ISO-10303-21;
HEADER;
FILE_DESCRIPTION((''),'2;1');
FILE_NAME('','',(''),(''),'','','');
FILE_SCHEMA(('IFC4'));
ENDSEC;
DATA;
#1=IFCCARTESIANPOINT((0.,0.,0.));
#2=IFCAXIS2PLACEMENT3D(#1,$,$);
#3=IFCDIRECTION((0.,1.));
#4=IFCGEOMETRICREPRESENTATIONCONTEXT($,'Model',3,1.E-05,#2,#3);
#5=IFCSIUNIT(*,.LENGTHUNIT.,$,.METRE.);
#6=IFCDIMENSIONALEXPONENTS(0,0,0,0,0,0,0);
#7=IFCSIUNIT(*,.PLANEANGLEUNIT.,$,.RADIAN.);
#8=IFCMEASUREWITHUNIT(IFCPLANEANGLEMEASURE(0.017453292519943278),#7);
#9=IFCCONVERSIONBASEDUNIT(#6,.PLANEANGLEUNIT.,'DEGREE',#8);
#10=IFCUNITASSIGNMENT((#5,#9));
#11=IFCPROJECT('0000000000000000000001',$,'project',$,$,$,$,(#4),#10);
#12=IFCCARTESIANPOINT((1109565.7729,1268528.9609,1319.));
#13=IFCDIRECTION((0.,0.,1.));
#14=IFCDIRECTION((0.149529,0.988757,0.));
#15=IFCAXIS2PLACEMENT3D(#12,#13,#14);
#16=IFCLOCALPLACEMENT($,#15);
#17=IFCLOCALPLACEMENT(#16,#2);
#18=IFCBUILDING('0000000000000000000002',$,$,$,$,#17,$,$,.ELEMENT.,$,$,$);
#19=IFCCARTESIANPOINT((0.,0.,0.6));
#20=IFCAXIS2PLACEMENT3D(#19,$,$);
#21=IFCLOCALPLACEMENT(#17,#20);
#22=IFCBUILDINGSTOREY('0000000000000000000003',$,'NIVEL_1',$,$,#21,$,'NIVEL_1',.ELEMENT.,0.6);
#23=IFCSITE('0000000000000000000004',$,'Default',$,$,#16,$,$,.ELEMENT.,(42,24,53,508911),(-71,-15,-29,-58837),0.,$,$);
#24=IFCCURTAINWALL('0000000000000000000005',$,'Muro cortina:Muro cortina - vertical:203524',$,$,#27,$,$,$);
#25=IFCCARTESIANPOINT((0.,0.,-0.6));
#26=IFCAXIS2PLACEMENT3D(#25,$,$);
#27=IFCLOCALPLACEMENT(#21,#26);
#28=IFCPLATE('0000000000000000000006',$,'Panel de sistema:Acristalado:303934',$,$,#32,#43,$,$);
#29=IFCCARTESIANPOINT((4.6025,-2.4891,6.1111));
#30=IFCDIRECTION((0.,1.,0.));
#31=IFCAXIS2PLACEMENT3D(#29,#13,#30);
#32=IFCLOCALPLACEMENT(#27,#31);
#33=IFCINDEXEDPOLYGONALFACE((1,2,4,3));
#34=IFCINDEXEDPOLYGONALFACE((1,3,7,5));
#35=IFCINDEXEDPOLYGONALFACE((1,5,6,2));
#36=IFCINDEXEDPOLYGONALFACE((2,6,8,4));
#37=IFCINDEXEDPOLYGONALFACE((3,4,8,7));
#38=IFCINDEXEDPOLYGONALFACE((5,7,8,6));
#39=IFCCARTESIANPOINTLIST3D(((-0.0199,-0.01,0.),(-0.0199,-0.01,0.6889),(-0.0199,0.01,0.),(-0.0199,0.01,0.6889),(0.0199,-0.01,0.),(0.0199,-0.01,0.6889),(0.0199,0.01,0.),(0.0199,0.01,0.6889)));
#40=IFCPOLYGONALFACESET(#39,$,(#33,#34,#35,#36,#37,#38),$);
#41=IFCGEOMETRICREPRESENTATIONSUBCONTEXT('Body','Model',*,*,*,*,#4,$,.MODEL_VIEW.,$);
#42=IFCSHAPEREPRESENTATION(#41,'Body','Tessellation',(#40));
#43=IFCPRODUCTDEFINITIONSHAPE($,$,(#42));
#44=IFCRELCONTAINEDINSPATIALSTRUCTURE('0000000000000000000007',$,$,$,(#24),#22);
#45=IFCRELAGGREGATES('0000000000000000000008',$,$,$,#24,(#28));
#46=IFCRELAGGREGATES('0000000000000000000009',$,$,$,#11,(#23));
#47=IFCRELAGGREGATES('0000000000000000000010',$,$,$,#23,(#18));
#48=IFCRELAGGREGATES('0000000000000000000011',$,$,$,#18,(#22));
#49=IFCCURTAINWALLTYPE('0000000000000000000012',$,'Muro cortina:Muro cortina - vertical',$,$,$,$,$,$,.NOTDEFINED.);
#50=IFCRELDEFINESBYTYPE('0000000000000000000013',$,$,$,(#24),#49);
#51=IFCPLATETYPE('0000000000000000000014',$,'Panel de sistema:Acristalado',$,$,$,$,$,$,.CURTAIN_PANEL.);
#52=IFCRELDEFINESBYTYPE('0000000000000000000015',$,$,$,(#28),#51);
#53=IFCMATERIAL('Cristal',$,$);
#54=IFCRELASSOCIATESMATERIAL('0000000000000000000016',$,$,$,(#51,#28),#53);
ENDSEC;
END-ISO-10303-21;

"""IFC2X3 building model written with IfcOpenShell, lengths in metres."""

from ifc_helpers import new_model, entity, si_unit, converted_unit, direction, frame, origin, origin_2d_with_axis, place, context, subcontext, project, spatial, rectangle, extrude, source, transform, mapped, material, type_object, type_shapes, element, aggregate, save


model = new_model("IFC2X3")

# Units and contexts
model_context = context("Model", 3, precision=1e-05, world=origin(), true_north=direction((0.0, 1.0)))
body_context = subcontext(model_context, "Body", "Model", "MODEL_VIEW")
ifc_project = project(units=[si_unit("LENGTHUNIT", "METRE"), converted_unit("PLANEANGLEUNIT", "DEGREE", entity("IfcPlaneAngleMeasure", 0.017453292519943278), si_unit("PLANEANGLEUNIT", "RADIAN"), dimensions=[0, 0, 0, 0, 0, 0, 0])], contexts=[model_context])

# Site, building, storey
site_placement = place(None, frame((1109565.7729, 1268528.9609, 1319.0), z_axis=(0.0, 0.0, 1.0), x_axis=(0.149529, 0.988757, 0.0)))
site = spatial("IfcSite", under=ifc_project, at=site_placement, Name="Default", CompositionType="ELEMENT", RefLatitude=(42, 24, 53, 508911), RefLongitude=(-71, -15, -29, -58837), RefElevation=0.0)
building_placement = place(site_placement, origin())
building = spatial("IfcBuilding", under=site, at=building_placement, CompositionType="ELEMENT")
storey_placement = place(building_placement, frame((0.0, 0.0, 0.6)))
storey = spatial("IfcBuildingStorey", under=building, at=storey_placement, Name="NIVEL_1", LongName="NIVEL_1", CompositionType="ELEMENT", Elevation=0.6)

# Shared definitions
curtain_wall_type = type_object("IfcCurtainWallType", Name="Muro cortina:Muro cortina - vertical", PredefinedType="NOTDEFINED")
ifc_material_1 = material(Name="Cristal")

# Curtain wall, plate
curtain_wall_1_placement = place(storey_placement, frame((0.0, 0.0, -0.6)))
curtain_wall_1 = element("IfcCurtainWall", 1, at=curtain_wall_1_placement, inside=storey, type_object=curtain_wall_type, Name="Muro cortina:Muro cortina - vertical:203524")
plate_type_1 = type_object("IfcPlateType", Name="Panel de sistema:Acristalado", PredefinedType="CURTAIN_PANEL", material=ifc_material_1)
shared_shape_1 = source(origin(), body_context, "Body", "SweptSolid", [
    extrude(rectangle(XDim=0.02, YDim=0.0398, at=origin_2d_with_axis()), frame((0.0, 0.0, 0.0), z_axis=(0.0, 0.0, 1.0), x_axis=(0.0, 1.0, 0.0)), (0.0, 0.0, 1.0), 0.6889),
])
type_shapes(plate_type_1, [shared_shape_1])
plate_1_placement = place(curtain_wall_1_placement, frame((4.6025, -2.4891, 6.1111), z_axis=(0.0, 0.0, 1.0), x_axis=(0.0, 1.0, 0.0)))
plate_1 = element("IfcPlate", 2, at=plate_1_placement, type_object=plate_type_1, material=ifc_material_1, Name="Panel de sistema:Acristalado:303934", context=body_context, shape_type="MappedRepresentation", body=[
    mapped(shared_shape_1, transform((0.0, 0.0, 0.0), scale=1.0)),
])
aggregate(curtain_wall_1, [plate_1])

save(model, "model.ifc")
